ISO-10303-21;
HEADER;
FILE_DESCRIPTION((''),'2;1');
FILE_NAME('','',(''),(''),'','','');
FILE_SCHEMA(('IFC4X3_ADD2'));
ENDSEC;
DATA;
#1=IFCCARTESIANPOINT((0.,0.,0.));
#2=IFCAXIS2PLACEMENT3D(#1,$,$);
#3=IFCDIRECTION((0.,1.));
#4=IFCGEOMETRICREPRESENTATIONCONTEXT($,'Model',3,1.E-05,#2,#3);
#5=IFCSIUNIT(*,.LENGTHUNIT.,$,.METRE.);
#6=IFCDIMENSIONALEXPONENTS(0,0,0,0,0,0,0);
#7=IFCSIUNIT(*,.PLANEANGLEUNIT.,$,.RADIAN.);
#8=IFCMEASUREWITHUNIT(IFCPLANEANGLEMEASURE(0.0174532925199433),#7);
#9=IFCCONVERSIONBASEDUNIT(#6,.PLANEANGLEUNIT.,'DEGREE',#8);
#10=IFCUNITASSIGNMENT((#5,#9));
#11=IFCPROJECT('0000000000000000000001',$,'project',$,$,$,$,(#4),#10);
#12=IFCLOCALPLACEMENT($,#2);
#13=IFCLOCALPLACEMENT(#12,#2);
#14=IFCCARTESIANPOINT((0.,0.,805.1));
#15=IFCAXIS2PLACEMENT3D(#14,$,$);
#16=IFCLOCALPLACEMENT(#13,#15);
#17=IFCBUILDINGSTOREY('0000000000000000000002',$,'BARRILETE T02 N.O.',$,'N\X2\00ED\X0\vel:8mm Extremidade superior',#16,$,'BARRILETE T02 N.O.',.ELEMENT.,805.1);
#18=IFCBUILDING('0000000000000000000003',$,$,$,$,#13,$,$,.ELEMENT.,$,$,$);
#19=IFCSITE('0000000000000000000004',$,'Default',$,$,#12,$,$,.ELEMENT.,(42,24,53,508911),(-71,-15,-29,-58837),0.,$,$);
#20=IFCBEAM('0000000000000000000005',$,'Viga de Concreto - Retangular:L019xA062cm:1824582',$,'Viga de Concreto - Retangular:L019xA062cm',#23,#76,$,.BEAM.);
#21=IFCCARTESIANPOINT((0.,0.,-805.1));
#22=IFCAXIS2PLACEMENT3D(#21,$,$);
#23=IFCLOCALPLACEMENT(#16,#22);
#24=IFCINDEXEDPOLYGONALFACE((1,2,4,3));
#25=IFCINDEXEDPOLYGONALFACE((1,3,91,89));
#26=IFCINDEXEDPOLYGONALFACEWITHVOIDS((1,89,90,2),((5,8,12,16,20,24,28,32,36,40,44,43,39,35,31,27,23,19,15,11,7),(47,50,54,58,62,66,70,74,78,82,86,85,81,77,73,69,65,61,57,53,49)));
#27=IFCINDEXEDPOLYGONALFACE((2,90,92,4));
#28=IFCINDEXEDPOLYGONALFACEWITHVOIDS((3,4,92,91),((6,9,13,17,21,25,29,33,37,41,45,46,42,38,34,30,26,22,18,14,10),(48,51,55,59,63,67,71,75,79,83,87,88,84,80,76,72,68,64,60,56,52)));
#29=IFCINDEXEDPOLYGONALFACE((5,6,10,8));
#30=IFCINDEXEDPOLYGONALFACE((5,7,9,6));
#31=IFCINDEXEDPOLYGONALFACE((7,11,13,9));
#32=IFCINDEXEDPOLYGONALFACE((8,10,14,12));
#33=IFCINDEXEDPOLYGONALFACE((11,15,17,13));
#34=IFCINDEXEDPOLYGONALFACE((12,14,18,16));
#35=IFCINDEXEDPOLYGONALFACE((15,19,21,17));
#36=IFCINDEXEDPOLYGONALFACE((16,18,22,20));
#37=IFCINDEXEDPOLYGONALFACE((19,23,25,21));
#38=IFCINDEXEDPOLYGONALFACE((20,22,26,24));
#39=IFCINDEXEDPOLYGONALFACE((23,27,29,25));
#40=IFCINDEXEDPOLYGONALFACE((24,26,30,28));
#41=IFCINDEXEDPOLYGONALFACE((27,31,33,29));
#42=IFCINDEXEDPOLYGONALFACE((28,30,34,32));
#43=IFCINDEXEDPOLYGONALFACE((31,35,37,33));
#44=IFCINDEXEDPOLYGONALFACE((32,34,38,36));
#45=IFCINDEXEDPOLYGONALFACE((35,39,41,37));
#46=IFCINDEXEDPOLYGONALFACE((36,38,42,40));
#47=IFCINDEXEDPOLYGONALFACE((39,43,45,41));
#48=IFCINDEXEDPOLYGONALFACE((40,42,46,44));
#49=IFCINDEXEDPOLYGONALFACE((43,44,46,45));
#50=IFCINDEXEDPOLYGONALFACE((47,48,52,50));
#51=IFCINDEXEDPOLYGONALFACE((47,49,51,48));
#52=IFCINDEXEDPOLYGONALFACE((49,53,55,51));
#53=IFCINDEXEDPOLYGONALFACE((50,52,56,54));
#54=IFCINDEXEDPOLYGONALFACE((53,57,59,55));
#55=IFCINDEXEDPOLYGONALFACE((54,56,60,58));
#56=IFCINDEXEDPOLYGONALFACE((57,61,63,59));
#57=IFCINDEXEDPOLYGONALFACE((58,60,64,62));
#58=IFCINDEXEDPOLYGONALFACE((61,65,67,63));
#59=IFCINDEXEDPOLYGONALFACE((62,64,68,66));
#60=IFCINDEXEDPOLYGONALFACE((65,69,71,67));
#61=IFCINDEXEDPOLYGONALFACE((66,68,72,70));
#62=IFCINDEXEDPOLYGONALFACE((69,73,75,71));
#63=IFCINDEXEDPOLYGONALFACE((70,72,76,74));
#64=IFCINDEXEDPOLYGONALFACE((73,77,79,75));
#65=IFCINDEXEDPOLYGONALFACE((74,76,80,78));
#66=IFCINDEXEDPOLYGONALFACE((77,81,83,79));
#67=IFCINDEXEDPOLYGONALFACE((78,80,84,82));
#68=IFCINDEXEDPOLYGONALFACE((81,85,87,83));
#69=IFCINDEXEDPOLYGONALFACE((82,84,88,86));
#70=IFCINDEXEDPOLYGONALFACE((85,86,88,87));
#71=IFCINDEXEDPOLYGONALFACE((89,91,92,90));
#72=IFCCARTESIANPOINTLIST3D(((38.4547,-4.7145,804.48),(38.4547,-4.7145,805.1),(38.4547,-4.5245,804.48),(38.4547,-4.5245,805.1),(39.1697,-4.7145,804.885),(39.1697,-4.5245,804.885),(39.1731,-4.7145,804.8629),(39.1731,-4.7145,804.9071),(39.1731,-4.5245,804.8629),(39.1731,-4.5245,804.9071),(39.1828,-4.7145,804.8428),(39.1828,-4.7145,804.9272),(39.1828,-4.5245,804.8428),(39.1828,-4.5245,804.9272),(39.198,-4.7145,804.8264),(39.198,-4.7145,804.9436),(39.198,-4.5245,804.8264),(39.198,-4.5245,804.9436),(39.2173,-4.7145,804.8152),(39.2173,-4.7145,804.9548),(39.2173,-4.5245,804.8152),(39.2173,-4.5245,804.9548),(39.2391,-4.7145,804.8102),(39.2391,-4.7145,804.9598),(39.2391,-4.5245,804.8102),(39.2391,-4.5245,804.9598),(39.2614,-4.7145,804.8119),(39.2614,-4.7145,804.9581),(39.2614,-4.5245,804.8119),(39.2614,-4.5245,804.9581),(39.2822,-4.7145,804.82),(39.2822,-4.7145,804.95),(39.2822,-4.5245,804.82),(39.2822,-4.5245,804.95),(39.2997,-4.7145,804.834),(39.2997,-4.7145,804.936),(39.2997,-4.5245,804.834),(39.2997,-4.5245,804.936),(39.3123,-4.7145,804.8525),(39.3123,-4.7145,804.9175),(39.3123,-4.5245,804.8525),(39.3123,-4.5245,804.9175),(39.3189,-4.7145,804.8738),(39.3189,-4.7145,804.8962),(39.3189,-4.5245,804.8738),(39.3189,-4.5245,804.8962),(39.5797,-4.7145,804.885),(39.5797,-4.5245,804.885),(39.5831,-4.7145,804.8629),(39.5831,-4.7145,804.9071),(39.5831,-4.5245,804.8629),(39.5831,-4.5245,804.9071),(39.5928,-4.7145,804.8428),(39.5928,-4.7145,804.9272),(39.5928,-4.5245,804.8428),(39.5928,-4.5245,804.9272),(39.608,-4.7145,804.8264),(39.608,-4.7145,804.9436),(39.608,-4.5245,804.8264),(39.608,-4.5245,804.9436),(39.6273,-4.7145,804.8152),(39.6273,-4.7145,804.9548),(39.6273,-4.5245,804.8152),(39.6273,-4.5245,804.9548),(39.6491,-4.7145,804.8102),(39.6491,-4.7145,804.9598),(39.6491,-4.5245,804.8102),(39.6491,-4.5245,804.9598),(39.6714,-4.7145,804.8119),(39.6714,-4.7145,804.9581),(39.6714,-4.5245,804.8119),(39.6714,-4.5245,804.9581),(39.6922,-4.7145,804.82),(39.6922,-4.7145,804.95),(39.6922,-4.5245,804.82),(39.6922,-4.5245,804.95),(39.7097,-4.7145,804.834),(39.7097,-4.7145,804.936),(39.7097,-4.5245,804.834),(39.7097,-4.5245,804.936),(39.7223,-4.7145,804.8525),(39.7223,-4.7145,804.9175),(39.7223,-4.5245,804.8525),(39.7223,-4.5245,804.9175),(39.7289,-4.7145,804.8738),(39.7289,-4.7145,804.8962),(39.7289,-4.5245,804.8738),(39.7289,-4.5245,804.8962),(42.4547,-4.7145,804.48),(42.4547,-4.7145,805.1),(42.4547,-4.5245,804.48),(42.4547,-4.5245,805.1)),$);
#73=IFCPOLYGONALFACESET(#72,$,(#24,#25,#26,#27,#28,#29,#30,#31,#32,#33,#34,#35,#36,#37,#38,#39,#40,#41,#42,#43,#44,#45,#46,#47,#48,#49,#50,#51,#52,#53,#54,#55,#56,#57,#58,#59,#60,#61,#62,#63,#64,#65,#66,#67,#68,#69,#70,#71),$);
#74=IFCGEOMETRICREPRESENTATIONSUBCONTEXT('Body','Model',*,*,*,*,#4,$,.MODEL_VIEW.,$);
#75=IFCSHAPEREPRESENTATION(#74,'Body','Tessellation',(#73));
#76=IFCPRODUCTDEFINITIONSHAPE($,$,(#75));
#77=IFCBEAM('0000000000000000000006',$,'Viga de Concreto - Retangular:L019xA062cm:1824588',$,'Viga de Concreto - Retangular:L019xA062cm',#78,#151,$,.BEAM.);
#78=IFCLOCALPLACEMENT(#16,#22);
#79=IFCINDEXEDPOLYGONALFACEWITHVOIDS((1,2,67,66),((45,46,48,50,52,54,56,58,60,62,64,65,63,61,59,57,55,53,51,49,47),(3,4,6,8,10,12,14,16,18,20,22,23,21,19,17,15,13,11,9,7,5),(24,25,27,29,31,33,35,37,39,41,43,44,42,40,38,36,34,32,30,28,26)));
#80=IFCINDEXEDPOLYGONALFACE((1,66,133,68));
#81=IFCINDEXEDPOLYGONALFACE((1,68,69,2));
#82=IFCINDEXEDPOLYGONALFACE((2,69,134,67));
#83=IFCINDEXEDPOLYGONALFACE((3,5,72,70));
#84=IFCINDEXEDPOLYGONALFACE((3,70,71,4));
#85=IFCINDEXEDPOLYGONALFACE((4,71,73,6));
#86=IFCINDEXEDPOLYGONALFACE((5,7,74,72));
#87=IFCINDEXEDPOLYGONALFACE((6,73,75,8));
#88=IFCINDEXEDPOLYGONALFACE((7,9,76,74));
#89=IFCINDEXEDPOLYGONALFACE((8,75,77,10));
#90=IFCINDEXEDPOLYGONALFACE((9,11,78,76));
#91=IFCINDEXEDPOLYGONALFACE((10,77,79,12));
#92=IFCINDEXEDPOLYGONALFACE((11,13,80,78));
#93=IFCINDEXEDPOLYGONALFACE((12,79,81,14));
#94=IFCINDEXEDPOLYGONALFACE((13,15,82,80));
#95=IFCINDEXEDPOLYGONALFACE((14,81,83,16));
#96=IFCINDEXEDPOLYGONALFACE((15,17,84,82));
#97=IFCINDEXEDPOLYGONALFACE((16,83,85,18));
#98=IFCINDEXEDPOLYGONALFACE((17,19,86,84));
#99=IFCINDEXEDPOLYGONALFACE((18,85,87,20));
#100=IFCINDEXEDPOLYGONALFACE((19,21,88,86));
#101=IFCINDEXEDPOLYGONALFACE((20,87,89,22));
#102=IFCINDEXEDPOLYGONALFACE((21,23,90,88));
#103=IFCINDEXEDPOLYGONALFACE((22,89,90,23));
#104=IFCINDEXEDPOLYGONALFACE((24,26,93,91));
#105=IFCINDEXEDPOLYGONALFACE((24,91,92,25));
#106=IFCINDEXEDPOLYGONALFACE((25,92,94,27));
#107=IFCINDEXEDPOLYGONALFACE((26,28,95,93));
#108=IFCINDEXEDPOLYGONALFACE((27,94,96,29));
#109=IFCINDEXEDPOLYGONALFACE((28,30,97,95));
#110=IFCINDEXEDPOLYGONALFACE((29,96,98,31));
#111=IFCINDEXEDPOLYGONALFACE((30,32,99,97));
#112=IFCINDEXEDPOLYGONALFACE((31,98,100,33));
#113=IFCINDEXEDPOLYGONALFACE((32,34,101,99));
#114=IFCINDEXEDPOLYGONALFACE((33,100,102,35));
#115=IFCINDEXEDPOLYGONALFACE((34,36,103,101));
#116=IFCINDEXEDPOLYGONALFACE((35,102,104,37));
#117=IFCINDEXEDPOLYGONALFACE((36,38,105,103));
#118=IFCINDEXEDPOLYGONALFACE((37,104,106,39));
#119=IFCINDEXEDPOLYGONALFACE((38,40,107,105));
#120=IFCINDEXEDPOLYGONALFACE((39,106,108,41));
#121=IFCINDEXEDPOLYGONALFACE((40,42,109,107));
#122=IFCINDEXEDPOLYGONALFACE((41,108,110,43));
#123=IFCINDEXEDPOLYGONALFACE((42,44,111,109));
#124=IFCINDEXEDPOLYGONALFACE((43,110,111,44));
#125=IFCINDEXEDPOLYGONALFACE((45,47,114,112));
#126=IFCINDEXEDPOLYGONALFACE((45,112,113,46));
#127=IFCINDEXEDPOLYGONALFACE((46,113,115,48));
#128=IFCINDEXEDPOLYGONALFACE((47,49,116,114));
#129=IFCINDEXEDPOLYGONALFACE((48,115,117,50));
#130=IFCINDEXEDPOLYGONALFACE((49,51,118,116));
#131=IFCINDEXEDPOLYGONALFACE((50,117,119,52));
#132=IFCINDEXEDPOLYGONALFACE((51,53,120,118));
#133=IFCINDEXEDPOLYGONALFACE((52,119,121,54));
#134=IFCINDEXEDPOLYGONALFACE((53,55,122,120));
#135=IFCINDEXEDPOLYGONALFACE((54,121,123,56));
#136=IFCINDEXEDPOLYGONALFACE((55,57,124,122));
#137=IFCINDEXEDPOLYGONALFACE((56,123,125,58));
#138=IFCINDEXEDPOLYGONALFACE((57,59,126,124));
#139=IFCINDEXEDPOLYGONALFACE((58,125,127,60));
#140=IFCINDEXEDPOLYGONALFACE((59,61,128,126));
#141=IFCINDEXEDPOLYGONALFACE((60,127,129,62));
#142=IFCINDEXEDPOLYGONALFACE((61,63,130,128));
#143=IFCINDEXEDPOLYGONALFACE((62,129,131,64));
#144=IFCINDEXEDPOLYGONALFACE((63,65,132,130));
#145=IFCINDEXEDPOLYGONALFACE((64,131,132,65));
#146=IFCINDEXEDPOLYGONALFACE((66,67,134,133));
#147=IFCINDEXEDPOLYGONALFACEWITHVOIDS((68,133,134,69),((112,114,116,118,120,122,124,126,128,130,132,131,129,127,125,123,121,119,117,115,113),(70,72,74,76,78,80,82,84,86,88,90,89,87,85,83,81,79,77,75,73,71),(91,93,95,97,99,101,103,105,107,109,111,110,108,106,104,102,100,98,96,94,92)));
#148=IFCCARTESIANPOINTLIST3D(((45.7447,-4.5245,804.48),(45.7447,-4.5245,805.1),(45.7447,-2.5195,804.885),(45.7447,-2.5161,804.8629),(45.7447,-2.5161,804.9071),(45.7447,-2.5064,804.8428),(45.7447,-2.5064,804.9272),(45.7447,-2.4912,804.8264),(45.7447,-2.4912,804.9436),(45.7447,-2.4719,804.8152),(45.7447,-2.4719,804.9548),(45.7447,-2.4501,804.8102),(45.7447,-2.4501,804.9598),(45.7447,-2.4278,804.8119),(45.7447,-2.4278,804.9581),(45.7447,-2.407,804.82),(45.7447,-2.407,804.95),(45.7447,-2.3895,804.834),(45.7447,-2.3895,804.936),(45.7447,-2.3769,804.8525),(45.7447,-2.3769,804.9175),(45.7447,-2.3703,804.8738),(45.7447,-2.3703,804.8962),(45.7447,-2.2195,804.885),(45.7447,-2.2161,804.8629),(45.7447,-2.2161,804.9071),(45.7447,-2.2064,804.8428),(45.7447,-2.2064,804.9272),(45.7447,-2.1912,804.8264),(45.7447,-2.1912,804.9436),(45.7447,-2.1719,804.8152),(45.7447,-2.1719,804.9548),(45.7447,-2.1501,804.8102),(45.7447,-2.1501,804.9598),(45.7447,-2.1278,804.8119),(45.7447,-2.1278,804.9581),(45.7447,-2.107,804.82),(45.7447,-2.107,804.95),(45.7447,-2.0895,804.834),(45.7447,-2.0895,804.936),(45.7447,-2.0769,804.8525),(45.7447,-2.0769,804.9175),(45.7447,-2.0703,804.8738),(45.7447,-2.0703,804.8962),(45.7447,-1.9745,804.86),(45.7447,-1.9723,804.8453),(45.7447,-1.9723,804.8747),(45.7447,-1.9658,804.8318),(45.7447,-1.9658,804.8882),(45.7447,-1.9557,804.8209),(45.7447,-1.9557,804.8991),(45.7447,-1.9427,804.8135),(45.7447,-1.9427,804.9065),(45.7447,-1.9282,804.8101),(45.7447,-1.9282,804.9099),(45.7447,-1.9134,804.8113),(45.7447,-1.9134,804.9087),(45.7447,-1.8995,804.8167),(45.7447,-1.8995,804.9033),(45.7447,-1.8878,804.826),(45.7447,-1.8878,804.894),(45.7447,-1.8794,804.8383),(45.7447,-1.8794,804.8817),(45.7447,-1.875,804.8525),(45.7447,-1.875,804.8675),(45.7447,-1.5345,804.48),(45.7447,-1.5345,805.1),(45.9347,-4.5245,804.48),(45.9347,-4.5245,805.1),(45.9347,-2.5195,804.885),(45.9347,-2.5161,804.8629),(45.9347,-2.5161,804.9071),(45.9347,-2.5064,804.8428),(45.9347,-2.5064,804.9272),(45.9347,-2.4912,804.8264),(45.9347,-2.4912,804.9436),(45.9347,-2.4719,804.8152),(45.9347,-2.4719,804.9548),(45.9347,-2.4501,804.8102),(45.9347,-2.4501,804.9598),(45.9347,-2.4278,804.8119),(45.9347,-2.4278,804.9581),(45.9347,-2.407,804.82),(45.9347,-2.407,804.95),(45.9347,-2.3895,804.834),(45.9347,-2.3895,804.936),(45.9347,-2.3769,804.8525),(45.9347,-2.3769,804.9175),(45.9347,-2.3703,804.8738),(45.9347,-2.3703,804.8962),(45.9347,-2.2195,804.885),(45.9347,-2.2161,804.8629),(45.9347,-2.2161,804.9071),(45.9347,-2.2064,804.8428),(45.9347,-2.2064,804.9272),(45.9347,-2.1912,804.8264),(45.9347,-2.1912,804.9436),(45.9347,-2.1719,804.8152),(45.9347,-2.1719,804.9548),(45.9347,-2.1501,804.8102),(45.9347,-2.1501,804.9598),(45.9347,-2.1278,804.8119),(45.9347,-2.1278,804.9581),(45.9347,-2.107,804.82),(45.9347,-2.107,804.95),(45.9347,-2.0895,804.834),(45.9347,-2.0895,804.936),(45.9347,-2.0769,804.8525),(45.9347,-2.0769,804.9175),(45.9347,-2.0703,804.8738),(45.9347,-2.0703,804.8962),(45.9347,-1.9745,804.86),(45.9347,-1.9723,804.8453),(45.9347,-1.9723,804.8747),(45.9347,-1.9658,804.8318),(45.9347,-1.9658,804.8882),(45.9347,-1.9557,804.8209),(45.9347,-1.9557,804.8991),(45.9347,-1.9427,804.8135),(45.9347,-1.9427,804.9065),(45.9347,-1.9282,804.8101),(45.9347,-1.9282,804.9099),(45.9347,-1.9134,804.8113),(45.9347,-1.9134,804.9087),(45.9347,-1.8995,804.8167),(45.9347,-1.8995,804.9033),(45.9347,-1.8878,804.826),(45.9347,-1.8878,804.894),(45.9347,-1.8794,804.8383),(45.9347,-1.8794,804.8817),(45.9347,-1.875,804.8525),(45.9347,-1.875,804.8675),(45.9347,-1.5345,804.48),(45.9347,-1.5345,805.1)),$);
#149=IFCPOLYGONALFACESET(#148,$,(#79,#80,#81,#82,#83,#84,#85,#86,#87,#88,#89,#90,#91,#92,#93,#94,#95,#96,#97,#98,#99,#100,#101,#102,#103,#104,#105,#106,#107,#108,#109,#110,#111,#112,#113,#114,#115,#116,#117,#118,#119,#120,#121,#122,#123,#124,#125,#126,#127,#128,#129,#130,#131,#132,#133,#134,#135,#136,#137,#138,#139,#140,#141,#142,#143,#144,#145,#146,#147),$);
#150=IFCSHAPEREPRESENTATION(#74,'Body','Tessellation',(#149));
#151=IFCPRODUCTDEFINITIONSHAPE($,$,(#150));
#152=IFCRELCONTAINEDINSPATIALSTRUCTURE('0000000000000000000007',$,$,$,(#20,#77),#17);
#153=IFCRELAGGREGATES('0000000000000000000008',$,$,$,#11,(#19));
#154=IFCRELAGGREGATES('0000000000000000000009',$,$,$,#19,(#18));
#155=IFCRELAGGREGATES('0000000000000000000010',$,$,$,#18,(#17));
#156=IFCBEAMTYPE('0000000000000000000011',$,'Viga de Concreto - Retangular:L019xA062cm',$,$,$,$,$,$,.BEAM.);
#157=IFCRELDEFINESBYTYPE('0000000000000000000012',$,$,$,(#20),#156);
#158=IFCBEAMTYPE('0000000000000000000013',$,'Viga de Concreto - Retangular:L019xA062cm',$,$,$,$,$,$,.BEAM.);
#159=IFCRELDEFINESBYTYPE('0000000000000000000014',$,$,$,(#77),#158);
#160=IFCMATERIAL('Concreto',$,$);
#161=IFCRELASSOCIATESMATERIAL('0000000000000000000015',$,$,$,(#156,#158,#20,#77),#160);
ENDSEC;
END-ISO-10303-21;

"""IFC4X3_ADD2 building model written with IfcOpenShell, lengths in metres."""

from ifc_helpers import new_model, entity, si_unit, converted_unit, direction, frame, frame_2d, origin, origin_2d_with_axis, place, context, subcontext, project, spatial, rectangle, circle, extrude, boolean, source, transform, mapped, material, material_profile, profile_set, type_object, type_shapes, element, save


model = new_model("IFC4X3_ADD2")

# Units and contexts
model_context = context("Model", 3, precision=1e-05, world=origin(), true_north=direction((0.0, 1.0)))
body_context = subcontext(model_context, "Body", "Model", "MODEL_VIEW")
ifc_project = project(units=[si_unit("LENGTHUNIT", "METRE"), converted_unit("PLANEANGLEUNIT", "DEGREE", entity("IfcPlaneAngleMeasure", 0.0174532925199433), si_unit("PLANEANGLEUNIT", "RADIAN"), dimensions=[0, 0, 0, 0, 0, 0, 0])], contexts=[model_context])

# Site, building, storey
site_placement = place(None, origin())
site = spatial("IfcSite", under=ifc_project, at=site_placement, Name="Default", CompositionType="ELEMENT", RefLatitude=(42, 24, 53, 508911), RefLongitude=(-71, -15, -29, -58837), RefElevation=0.0)
building_placement = place(site_placement, origin())
building = spatial("IfcBuilding", under=site, at=building_placement, CompositionType="ELEMENT")
storey_placement = place(building_placement, frame((0.0, 0.0, 805.1)))
storey = spatial("IfcBuildingStorey", under=building, at=storey_placement, Name="BARRILETE T02 N.O.", ObjectType="Nível:8mm Extremidade superior", LongName="BARRILETE T02 N.O.", CompositionType="ELEMENT", Elevation=805.1)

# Shared definitions
ifc_material = material(Name="Concreto")

# Beams
ifc_material_profile_1 = material_profile(ifc_material, rectangle(XDim=0.62, YDim=0.19, at=frame_2d((0.0, 0.0), x_axis=(0.0, 1.0))), Name="L019xA062cm")
ifc_profile_set_1 = profile_set([ifc_material_profile_1], Name="L019xA062cm")
beam_type_1 = type_object("IfcBeamType", Name="Viga de Concreto - Retangular:L019xA062cm", PredefinedType="BEAM", material=ifc_profile_set_1)
shared_shape_1 = source(origin(), body_context, "Body", "CSG", [
    boolean("DIFFERENCE", boolean("DIFFERENCE", extrude(rectangle(XDim=0.62, YDim=0.19, at=frame_2d((0.0, 0.0), x_axis=(0.0, 1.0))), frame((42.4547, -4.6195, 804.79), z_axis=(-1.0, 0.0, 0.0), x_axis=(0.0, -1.0, 0.0)), (0.0, 0.0, 1.0), 4.0), extrude(circle(Radius=0.075, at=origin_2d_with_axis()), frame((39.6547, -4.5245, 804.885), z_axis=(0.0, -1.0, 0.0), x_axis=(-1.0, 0.0, 0.0)), (0.0, 0.0, 1.0), 0.19)), extrude(circle(Radius=0.075, at=origin_2d_with_axis()), frame((39.2447, -4.7145, 804.885), z_axis=(0.0, 1.0, 0.0), x_axis=(-1.0, 0.0, 0.0)), (0.0, 0.0, 1.0), 0.19)),
])
type_shapes(beam_type_1, [shared_shape_1])
beam_1_placement = place(storey_placement, frame((0.0, 0.0, -805.1)))
element("IfcBeam", 1, at=beam_1_placement, inside=storey, type_object=beam_type_1, material=ifc_material, Name="Viga de Concreto - Retangular:L019xA062cm:1824582", ObjectType="Viga de Concreto - Retangular:L019xA062cm", PredefinedType="BEAM", context=body_context, shape_type="MappedRepresentation", body=[
    mapped(shared_shape_1, transform((0.0, 0.0, 0.0), scale=1.0)),
])
beam_type_2 = type_object("IfcBeamType", Name="Viga de Concreto - Retangular:L019xA062cm", PredefinedType="BEAM", material=ifc_profile_set_1)
shared_shape_2 = source(origin(), body_context, "Body", "CSG", [
    boolean("DIFFERENCE", boolean("DIFFERENCE", boolean("DIFFERENCE", extrude(rectangle(XDim=0.62, YDim=0.19, at=frame_2d((0.0, 0.0), x_axis=(0.0, 1.0))), frame((45.8397, -1.5345, 804.79), z_axis=(0.0, -1.0, 0.0), x_axis=(-1.0, 0.0, 0.0)), (0.0, 0.0, 1.0), 2.99), extrude(circle(Radius=0.075, at=origin_2d_with_axis()), frame((45.7447, -2.1445, 804.885), z_axis=(1.0, 0.0, 0.0), x_axis=(0.0, -1.0, 0.0)), (0.0, 0.0, 1.0), 0.19)), extrude(circle(Radius=0.075, at=origin_2d_with_axis()), frame((45.9347, -2.4445, 804.885), z_axis=(-1.0, 0.0, 0.0), x_axis=(0.0, -1.0, 0.0)), (0.0, 0.0, 1.0), 0.19)), extrude(circle(Radius=0.05, at=origin_2d_with_axis()), frame((45.9347, -1.9245, 804.86), z_axis=(-1.0, 0.0, 0.0), x_axis=(0.0, -1.0, 0.0)), (0.0, 0.0, 1.0), 0.19)),
])
type_shapes(beam_type_2, [shared_shape_2])
beam_2_placement = place(storey_placement, frame((0.0, 0.0, -805.1)))
element("IfcBeam", 2, at=beam_2_placement, inside=storey, type_object=beam_type_2, material=ifc_material, Name="Viga de Concreto - Retangular:L019xA062cm:1824588", ObjectType="Viga de Concreto - Retangular:L019xA062cm", PredefinedType="BEAM", context=body_context, shape_type="MappedRepresentation", body=[
    mapped(shared_shape_2, transform((0.0, 0.0, 0.0), scale=1.0)),
])

save(model, "model.ifc")
